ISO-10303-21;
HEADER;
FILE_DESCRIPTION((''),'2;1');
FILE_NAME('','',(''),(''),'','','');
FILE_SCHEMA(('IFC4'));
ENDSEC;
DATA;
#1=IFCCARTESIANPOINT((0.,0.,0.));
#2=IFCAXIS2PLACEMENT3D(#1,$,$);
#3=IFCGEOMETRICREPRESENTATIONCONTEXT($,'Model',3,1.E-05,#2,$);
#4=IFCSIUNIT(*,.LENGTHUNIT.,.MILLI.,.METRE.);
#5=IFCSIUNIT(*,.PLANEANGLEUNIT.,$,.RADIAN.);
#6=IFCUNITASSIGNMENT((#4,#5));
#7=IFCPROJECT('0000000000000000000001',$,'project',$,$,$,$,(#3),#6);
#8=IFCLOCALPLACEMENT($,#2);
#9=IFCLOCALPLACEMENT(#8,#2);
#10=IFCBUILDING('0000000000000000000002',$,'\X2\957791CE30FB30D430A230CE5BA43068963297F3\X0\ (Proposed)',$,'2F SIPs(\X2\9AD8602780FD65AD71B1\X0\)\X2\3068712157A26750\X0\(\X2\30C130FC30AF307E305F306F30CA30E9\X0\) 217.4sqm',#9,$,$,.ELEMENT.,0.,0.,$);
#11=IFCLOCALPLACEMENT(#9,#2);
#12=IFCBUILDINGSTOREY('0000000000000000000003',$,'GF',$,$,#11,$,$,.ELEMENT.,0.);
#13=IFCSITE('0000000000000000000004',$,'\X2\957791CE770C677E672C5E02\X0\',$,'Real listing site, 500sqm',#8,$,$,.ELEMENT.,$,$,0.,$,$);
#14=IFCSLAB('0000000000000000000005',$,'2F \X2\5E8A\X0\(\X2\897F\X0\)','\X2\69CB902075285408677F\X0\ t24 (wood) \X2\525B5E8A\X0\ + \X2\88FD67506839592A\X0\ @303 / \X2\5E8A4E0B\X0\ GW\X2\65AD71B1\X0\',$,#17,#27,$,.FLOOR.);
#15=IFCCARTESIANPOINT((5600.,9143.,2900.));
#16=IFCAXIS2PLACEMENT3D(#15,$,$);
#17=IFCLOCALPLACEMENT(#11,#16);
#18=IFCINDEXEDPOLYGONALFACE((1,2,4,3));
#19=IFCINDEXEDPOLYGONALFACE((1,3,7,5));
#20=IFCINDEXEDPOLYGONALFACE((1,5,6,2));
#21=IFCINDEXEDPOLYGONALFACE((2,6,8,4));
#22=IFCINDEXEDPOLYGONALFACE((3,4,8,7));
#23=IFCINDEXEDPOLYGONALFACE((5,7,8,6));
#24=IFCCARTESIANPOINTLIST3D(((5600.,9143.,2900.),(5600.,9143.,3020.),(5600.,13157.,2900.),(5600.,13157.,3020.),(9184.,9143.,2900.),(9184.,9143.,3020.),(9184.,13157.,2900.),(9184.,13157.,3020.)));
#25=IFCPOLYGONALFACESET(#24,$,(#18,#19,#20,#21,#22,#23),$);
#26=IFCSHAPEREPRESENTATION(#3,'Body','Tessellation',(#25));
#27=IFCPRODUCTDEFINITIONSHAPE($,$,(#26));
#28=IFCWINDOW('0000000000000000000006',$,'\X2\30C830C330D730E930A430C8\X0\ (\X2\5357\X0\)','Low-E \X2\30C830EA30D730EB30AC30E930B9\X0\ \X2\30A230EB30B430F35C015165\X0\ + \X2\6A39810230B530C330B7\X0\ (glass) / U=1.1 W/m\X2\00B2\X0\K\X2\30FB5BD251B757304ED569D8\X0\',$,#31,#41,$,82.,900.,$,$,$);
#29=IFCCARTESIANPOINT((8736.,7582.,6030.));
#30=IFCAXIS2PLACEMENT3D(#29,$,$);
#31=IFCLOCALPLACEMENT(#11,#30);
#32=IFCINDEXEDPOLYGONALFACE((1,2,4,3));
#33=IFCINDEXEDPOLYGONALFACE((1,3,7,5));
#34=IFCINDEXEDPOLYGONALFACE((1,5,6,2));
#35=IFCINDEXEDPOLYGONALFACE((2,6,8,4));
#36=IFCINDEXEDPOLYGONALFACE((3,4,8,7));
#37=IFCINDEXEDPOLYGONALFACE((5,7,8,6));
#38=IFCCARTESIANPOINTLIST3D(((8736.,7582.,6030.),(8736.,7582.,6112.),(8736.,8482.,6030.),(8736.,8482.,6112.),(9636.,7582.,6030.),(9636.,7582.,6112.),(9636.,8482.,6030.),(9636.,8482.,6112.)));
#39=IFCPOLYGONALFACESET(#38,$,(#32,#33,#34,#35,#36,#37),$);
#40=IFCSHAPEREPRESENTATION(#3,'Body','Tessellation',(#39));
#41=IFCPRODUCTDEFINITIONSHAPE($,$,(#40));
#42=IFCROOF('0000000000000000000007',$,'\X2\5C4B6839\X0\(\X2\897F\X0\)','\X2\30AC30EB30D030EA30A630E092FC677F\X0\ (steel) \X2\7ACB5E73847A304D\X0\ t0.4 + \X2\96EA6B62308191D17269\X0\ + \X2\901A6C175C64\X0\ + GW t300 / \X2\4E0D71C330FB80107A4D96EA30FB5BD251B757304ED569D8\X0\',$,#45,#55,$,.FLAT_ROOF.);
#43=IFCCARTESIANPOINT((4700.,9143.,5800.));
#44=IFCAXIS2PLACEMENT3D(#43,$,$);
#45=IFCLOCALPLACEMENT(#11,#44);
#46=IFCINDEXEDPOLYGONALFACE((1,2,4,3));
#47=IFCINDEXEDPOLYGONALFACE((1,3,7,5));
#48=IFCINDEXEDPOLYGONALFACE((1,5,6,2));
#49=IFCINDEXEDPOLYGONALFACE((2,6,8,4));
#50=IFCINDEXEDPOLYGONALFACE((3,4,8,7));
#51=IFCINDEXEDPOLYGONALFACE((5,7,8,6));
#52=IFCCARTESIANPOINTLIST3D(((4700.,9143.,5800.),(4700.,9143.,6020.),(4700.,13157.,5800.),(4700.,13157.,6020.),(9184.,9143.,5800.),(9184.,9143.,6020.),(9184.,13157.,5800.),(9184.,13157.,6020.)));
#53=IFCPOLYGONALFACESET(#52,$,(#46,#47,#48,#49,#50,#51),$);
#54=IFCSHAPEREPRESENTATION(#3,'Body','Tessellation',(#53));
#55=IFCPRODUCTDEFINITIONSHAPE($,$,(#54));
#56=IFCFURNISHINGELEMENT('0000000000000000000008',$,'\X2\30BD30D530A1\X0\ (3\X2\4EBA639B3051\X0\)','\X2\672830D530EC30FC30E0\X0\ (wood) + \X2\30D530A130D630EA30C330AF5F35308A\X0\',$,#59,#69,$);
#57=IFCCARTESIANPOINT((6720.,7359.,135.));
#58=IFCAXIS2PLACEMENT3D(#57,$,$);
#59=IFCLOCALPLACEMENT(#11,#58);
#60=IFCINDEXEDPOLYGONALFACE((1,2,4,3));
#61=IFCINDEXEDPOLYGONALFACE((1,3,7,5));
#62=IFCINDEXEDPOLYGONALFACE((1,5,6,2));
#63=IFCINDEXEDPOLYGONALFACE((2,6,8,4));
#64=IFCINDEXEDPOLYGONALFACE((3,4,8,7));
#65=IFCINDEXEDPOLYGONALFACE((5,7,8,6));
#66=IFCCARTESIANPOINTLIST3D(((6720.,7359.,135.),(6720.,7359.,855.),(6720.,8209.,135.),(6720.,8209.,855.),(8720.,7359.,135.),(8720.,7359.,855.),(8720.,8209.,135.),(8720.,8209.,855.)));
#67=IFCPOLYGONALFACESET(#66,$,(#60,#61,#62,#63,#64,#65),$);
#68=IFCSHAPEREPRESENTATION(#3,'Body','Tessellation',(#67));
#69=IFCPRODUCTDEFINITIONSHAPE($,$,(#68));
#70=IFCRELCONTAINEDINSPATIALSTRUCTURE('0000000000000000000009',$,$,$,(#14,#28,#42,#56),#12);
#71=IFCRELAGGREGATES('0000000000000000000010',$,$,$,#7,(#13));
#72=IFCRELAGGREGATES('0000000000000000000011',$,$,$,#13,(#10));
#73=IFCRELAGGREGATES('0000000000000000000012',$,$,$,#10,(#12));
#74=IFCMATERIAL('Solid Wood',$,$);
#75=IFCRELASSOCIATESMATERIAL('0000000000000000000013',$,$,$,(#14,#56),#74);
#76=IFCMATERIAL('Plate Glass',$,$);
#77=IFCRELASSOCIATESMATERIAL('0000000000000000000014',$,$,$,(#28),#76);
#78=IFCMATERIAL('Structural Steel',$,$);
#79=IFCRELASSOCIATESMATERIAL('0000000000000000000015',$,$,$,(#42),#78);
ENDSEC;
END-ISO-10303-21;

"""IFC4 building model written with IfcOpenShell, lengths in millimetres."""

from ifc_helpers import new_model, si_unit, frame, frame_2d, origin, place, context, project, spatial, rectangle, extrude, material, element, save


model = new_model("IFC4")

# Units and contexts
model_context = context("Model", 3, precision=1e-05, world=origin())
ifc_project = project(units=[si_unit("LENGTHUNIT", "METRE", prefix="MILLI"), si_unit("PLANEANGLEUNIT", "RADIAN")], contexts=[model_context])

# Site, building, storey
site_placement = place(None, origin())
site = spatial("IfcSite", under=ifc_project, at=site_placement, Name="長野県松本市", ObjectType="Real listing site, 500sqm", CompositionType="ELEMENT", RefElevation=0.0)
building_placement = place(site_placement, origin())
building = spatial("IfcBuilding", under=site, at=building_placement, Name="長野・ピアノ室と防音 (Proposed)", ObjectType="2F SIPs(高性能断熱)と無垢材(チークまたはナラ) 217.4sqm", CompositionType="ELEMENT", ElevationOfRefHeight=0.0, ElevationOfTerrain=0.0)
storey_placement = place(building_placement, origin())
storey = spatial("IfcBuildingStorey", under=building, at=storey_placement, Name="GF", CompositionType="ELEMENT", Elevation=0.0)

# Shared definitions
ifc_material_1 = material(Name="Solid Wood")

# Slab
slab_1_placement = place(storey_placement, frame((5600.0, 9143.0, 2900.0)))
element("IfcSlab", 1, at=slab_1_placement, inside=storey, material=ifc_material_1, Name="2F 床(西)", Description="構造用合板 t24 (wood) 剛床 + 製材根太 @303 / 床下 GW断熱", PredefinedType="FLOOR", context=model_context, shape_type="SweptSolid", body=[
    extrude(rectangle(XDim=3584.0, YDim=4014.0, at=frame_2d((1792.0, 2007.0))), frame((5600.0, 9143.0, 2900.0)), (0.0, 0.0, 1.0), 120.0),
])

# Window
ifc_material_2 = material(Name="Plate Glass")
window_placement = place(storey_placement, frame((8736.0, 7582.0, 6030.0)))
element("IfcWindow", 2, at=window_placement, inside=storey, material=ifc_material_2, Name="トップライト (南)", Description="Low-E トリプルガラス アルゴン封入 + 樹脂サッシ (glass) / U=1.1 W/m²K・寒冷地仕様", OverallHeight=82.0, OverallWidth=900.0, context=model_context, shape_type="SweptSolid", body=[
    extrude(rectangle(XDim=900.0, YDim=900.0, at=frame_2d((450.0, 450.0))), frame((8736.0, 7582.0, 6030.0)), (0.0, 0.0, 1.0), 82.0),
])

# Roof
ifc_material_3 = material(Name="Structural Steel")
for number, where, name in (
    (3, (4700.0, 9143.0, 5800.0), "屋根(西)"),
):
    element("IfcRoof", number, at=place(storey_placement, frame(where)), inside=storey, material=ifc_material_3, Name=name, Description="ガルバリウム鋼板 (steel) 立平葺き t0.4 + 雪止め金物 + 通気層 + GW t300 / 不燃・耐積雪・寒冷地仕様", PredefinedType="FLAT_ROOF", context=model_context, shape_type="SweptSolid", body=[
        extrude(rectangle(XDim=4484.0, YDim=4014.0, at=frame_2d((2242.0, 2007.0))), frame((4700.0, 9143.0, 5800.0)), (0.0, 0.0, 1.0), 220.0),
    ])

# Furnishing element
furnishing_placement = place(storey_placement, frame((6720.0, 7359.0, 135.0)))
element("IfcFurnishingElement", 4, at=furnishing_placement, inside=storey, material=ifc_material_1, Name="ソファ (3人掛け)", Description="木フレーム (wood) + ファブリック張り", context=model_context, shape_type="SweptSolid", body=[
    extrude(rectangle(XDim=2000.0, YDim=850.0, at=frame_2d((1000.0, 425.0))), frame((6720.0, 7359.0, 135.0)), (0.0, 0.0, 1.0), 720.0),
])

save(model, "model.ifc")
